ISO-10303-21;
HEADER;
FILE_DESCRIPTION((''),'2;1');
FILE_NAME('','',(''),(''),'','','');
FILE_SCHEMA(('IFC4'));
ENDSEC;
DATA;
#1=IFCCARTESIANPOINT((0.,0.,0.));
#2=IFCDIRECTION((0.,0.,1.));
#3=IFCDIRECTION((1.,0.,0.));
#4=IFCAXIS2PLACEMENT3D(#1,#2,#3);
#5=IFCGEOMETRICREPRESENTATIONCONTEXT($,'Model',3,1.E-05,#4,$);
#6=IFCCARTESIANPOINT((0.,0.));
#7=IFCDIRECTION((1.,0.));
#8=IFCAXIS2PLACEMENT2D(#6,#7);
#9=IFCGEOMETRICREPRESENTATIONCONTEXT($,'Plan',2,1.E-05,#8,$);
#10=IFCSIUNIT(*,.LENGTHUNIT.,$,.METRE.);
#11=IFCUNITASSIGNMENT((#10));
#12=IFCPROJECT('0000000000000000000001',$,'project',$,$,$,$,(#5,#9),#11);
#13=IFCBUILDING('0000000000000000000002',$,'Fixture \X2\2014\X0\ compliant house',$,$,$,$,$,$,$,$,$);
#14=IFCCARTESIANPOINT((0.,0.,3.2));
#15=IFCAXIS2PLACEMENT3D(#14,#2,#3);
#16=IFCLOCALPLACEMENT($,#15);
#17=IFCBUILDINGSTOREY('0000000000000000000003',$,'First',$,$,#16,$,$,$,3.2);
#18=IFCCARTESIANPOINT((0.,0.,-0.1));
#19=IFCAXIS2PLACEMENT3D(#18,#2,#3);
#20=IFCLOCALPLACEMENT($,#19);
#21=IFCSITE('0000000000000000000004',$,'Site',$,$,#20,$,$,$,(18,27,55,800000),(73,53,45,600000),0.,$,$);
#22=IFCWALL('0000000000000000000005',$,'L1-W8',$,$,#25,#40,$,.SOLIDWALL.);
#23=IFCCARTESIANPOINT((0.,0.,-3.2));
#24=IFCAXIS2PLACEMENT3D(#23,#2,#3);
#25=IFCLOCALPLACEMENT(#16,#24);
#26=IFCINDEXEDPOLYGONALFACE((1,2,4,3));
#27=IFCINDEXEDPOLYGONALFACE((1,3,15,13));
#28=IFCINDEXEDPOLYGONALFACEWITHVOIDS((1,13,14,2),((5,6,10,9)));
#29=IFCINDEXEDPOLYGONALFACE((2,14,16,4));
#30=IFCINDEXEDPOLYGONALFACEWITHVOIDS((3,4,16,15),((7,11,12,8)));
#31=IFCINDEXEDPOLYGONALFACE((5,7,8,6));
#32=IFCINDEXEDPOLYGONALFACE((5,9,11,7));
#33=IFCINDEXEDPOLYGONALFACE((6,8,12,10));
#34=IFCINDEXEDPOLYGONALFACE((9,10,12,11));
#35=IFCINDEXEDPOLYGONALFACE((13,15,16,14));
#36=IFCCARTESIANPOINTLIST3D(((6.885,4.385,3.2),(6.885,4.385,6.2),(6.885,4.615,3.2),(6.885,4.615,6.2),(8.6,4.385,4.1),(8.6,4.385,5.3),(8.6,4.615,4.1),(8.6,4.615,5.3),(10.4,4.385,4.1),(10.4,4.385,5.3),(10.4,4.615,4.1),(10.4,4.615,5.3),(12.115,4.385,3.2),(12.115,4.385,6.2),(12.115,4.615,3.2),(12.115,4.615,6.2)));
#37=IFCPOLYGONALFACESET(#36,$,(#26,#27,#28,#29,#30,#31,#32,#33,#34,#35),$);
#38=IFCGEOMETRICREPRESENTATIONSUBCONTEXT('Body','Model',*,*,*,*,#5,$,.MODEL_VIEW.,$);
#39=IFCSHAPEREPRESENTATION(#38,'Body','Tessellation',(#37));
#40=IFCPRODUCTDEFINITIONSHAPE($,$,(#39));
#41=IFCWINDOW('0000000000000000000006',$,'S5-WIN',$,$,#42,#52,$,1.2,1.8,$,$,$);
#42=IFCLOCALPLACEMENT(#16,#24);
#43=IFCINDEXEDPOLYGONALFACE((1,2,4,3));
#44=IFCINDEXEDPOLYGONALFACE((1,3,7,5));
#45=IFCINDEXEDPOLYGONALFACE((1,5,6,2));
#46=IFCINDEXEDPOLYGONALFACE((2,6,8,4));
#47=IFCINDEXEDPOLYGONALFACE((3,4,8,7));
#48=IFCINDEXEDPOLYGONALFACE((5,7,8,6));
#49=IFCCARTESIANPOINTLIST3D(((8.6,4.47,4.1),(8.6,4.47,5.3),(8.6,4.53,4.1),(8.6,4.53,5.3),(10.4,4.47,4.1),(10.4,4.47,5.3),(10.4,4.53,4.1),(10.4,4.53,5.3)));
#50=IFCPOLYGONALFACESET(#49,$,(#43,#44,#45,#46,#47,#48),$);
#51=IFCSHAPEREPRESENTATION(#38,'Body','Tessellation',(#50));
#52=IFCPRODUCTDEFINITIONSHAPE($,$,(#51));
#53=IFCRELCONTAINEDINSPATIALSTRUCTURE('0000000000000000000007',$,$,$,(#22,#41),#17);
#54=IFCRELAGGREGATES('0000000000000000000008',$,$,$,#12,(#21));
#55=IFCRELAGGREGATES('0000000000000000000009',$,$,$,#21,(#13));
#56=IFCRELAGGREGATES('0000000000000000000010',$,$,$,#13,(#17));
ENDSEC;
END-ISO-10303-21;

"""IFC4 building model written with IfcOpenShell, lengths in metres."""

from ifc_helpers import new_model, si_unit, frame, origin_with_axes, origin_2d_with_axis, place, context, subcontext, project, spatial, line, indexed_curve, outline, extrude, element, fill, save


model = new_model("IFC4")

# Units and contexts
model_context = context("Model", 3, precision=1e-05, world=origin_with_axes())
plan_context = context("Plan", 2, precision=1e-05, world=origin_2d_with_axis())
body_context = subcontext(model_context, "Body", "Model", "MODEL_VIEW")
ifc_project = project(units=[si_unit("LENGTHUNIT", "METRE")], contexts=[model_context, plan_context])

# Site, building, storey
site_placement = place(None, frame((0.0, 0.0, -0.1), z_axis=(0.0, 0.0, 1.0), x_axis=(1.0, 0.0, 0.0)))
site = spatial("IfcSite", under=ifc_project, at=site_placement, Name="Site", RefLatitude=(18, 27, 55, 800000), RefLongitude=(73, 53, 45, 600000), RefElevation=0.0)
building = spatial("IfcBuilding", under=site, Name="Fixture — compliant house")
storey_placement = place(None, frame((0.0, 0.0, 3.2), z_axis=(0.0, 0.0, 1.0), x_axis=(1.0, 0.0, 0.0)))
storey = spatial("IfcBuildingStorey", under=building, at=storey_placement, Name="First", Elevation=3.2)

# Wall, opening, window
wall_1_placement = place(storey_placement, frame((0.0, 0.0, -3.2), z_axis=(0.0, 0.0, 1.0), x_axis=(1.0, 0.0, 0.0)))
wall_1 = element("IfcWall", 1, at=wall_1_placement, inside=storey, Name="L1-W8", PredefinedType="SOLIDWALL", context=body_context, shape_type="SweptSolid", body=[
    extrude(outline(indexed_curve([(6.885, 4.615), (12.115, 4.615), (12.115, 4.385), (6.885, 4.385)], segments=[line(1, 2, 3, 4, 1)])), frame((0.0, 0.0, 3.2), z_axis=(0.0, 0.0, 1.0), x_axis=(1.0, 0.0, 0.0)), (0.0, 0.0, 1.0), 3.0),
])
opening_1_placement = place(wall_1_placement, origin_with_axes())
opening_1 = element("IfcOpeningElement", 2, at=opening_1_placement, cuts=wall_1, context=body_context, shape_type="SweptSolid", body=[
    extrude(outline(indexed_curve([(8.6, 4.665), (10.4, 4.665), (10.4, 4.335), (8.6, 4.335)], segments=[line(1, 2, 3, 4, 1)])), frame((0.0, 0.0, 4.1), z_axis=(0.0, 0.0, 1.0), x_axis=(1.0, 0.0, 0.0)), (0.0, 0.0, 1.0), 1.2),
])
window_1_placement = place(storey_placement, frame((0.0, 0.0, -3.2), z_axis=(0.0, 0.0, 1.0), x_axis=(1.0, 0.0, 0.0)))
window_1 = element("IfcWindow", 3, at=window_1_placement, inside=storey, Name="S5-WIN", OverallHeight=1.2, OverallWidth=1.8, context=body_context, shape_type="SweptSolid", body=[
    extrude(outline(indexed_curve([(8.6, 4.53), (10.4, 4.53), (10.4, 4.47), (8.6, 4.47)], segments=[line(1, 2, 3, 4, 1)])), frame((0.0, 0.0, 4.1), z_axis=(0.0, 0.0, 1.0), x_axis=(1.0, 0.0, 0.0)), (0.0, 0.0, 1.0), 1.2),
])
fill(opening_1, window_1)

save(model, "model.ifc")
